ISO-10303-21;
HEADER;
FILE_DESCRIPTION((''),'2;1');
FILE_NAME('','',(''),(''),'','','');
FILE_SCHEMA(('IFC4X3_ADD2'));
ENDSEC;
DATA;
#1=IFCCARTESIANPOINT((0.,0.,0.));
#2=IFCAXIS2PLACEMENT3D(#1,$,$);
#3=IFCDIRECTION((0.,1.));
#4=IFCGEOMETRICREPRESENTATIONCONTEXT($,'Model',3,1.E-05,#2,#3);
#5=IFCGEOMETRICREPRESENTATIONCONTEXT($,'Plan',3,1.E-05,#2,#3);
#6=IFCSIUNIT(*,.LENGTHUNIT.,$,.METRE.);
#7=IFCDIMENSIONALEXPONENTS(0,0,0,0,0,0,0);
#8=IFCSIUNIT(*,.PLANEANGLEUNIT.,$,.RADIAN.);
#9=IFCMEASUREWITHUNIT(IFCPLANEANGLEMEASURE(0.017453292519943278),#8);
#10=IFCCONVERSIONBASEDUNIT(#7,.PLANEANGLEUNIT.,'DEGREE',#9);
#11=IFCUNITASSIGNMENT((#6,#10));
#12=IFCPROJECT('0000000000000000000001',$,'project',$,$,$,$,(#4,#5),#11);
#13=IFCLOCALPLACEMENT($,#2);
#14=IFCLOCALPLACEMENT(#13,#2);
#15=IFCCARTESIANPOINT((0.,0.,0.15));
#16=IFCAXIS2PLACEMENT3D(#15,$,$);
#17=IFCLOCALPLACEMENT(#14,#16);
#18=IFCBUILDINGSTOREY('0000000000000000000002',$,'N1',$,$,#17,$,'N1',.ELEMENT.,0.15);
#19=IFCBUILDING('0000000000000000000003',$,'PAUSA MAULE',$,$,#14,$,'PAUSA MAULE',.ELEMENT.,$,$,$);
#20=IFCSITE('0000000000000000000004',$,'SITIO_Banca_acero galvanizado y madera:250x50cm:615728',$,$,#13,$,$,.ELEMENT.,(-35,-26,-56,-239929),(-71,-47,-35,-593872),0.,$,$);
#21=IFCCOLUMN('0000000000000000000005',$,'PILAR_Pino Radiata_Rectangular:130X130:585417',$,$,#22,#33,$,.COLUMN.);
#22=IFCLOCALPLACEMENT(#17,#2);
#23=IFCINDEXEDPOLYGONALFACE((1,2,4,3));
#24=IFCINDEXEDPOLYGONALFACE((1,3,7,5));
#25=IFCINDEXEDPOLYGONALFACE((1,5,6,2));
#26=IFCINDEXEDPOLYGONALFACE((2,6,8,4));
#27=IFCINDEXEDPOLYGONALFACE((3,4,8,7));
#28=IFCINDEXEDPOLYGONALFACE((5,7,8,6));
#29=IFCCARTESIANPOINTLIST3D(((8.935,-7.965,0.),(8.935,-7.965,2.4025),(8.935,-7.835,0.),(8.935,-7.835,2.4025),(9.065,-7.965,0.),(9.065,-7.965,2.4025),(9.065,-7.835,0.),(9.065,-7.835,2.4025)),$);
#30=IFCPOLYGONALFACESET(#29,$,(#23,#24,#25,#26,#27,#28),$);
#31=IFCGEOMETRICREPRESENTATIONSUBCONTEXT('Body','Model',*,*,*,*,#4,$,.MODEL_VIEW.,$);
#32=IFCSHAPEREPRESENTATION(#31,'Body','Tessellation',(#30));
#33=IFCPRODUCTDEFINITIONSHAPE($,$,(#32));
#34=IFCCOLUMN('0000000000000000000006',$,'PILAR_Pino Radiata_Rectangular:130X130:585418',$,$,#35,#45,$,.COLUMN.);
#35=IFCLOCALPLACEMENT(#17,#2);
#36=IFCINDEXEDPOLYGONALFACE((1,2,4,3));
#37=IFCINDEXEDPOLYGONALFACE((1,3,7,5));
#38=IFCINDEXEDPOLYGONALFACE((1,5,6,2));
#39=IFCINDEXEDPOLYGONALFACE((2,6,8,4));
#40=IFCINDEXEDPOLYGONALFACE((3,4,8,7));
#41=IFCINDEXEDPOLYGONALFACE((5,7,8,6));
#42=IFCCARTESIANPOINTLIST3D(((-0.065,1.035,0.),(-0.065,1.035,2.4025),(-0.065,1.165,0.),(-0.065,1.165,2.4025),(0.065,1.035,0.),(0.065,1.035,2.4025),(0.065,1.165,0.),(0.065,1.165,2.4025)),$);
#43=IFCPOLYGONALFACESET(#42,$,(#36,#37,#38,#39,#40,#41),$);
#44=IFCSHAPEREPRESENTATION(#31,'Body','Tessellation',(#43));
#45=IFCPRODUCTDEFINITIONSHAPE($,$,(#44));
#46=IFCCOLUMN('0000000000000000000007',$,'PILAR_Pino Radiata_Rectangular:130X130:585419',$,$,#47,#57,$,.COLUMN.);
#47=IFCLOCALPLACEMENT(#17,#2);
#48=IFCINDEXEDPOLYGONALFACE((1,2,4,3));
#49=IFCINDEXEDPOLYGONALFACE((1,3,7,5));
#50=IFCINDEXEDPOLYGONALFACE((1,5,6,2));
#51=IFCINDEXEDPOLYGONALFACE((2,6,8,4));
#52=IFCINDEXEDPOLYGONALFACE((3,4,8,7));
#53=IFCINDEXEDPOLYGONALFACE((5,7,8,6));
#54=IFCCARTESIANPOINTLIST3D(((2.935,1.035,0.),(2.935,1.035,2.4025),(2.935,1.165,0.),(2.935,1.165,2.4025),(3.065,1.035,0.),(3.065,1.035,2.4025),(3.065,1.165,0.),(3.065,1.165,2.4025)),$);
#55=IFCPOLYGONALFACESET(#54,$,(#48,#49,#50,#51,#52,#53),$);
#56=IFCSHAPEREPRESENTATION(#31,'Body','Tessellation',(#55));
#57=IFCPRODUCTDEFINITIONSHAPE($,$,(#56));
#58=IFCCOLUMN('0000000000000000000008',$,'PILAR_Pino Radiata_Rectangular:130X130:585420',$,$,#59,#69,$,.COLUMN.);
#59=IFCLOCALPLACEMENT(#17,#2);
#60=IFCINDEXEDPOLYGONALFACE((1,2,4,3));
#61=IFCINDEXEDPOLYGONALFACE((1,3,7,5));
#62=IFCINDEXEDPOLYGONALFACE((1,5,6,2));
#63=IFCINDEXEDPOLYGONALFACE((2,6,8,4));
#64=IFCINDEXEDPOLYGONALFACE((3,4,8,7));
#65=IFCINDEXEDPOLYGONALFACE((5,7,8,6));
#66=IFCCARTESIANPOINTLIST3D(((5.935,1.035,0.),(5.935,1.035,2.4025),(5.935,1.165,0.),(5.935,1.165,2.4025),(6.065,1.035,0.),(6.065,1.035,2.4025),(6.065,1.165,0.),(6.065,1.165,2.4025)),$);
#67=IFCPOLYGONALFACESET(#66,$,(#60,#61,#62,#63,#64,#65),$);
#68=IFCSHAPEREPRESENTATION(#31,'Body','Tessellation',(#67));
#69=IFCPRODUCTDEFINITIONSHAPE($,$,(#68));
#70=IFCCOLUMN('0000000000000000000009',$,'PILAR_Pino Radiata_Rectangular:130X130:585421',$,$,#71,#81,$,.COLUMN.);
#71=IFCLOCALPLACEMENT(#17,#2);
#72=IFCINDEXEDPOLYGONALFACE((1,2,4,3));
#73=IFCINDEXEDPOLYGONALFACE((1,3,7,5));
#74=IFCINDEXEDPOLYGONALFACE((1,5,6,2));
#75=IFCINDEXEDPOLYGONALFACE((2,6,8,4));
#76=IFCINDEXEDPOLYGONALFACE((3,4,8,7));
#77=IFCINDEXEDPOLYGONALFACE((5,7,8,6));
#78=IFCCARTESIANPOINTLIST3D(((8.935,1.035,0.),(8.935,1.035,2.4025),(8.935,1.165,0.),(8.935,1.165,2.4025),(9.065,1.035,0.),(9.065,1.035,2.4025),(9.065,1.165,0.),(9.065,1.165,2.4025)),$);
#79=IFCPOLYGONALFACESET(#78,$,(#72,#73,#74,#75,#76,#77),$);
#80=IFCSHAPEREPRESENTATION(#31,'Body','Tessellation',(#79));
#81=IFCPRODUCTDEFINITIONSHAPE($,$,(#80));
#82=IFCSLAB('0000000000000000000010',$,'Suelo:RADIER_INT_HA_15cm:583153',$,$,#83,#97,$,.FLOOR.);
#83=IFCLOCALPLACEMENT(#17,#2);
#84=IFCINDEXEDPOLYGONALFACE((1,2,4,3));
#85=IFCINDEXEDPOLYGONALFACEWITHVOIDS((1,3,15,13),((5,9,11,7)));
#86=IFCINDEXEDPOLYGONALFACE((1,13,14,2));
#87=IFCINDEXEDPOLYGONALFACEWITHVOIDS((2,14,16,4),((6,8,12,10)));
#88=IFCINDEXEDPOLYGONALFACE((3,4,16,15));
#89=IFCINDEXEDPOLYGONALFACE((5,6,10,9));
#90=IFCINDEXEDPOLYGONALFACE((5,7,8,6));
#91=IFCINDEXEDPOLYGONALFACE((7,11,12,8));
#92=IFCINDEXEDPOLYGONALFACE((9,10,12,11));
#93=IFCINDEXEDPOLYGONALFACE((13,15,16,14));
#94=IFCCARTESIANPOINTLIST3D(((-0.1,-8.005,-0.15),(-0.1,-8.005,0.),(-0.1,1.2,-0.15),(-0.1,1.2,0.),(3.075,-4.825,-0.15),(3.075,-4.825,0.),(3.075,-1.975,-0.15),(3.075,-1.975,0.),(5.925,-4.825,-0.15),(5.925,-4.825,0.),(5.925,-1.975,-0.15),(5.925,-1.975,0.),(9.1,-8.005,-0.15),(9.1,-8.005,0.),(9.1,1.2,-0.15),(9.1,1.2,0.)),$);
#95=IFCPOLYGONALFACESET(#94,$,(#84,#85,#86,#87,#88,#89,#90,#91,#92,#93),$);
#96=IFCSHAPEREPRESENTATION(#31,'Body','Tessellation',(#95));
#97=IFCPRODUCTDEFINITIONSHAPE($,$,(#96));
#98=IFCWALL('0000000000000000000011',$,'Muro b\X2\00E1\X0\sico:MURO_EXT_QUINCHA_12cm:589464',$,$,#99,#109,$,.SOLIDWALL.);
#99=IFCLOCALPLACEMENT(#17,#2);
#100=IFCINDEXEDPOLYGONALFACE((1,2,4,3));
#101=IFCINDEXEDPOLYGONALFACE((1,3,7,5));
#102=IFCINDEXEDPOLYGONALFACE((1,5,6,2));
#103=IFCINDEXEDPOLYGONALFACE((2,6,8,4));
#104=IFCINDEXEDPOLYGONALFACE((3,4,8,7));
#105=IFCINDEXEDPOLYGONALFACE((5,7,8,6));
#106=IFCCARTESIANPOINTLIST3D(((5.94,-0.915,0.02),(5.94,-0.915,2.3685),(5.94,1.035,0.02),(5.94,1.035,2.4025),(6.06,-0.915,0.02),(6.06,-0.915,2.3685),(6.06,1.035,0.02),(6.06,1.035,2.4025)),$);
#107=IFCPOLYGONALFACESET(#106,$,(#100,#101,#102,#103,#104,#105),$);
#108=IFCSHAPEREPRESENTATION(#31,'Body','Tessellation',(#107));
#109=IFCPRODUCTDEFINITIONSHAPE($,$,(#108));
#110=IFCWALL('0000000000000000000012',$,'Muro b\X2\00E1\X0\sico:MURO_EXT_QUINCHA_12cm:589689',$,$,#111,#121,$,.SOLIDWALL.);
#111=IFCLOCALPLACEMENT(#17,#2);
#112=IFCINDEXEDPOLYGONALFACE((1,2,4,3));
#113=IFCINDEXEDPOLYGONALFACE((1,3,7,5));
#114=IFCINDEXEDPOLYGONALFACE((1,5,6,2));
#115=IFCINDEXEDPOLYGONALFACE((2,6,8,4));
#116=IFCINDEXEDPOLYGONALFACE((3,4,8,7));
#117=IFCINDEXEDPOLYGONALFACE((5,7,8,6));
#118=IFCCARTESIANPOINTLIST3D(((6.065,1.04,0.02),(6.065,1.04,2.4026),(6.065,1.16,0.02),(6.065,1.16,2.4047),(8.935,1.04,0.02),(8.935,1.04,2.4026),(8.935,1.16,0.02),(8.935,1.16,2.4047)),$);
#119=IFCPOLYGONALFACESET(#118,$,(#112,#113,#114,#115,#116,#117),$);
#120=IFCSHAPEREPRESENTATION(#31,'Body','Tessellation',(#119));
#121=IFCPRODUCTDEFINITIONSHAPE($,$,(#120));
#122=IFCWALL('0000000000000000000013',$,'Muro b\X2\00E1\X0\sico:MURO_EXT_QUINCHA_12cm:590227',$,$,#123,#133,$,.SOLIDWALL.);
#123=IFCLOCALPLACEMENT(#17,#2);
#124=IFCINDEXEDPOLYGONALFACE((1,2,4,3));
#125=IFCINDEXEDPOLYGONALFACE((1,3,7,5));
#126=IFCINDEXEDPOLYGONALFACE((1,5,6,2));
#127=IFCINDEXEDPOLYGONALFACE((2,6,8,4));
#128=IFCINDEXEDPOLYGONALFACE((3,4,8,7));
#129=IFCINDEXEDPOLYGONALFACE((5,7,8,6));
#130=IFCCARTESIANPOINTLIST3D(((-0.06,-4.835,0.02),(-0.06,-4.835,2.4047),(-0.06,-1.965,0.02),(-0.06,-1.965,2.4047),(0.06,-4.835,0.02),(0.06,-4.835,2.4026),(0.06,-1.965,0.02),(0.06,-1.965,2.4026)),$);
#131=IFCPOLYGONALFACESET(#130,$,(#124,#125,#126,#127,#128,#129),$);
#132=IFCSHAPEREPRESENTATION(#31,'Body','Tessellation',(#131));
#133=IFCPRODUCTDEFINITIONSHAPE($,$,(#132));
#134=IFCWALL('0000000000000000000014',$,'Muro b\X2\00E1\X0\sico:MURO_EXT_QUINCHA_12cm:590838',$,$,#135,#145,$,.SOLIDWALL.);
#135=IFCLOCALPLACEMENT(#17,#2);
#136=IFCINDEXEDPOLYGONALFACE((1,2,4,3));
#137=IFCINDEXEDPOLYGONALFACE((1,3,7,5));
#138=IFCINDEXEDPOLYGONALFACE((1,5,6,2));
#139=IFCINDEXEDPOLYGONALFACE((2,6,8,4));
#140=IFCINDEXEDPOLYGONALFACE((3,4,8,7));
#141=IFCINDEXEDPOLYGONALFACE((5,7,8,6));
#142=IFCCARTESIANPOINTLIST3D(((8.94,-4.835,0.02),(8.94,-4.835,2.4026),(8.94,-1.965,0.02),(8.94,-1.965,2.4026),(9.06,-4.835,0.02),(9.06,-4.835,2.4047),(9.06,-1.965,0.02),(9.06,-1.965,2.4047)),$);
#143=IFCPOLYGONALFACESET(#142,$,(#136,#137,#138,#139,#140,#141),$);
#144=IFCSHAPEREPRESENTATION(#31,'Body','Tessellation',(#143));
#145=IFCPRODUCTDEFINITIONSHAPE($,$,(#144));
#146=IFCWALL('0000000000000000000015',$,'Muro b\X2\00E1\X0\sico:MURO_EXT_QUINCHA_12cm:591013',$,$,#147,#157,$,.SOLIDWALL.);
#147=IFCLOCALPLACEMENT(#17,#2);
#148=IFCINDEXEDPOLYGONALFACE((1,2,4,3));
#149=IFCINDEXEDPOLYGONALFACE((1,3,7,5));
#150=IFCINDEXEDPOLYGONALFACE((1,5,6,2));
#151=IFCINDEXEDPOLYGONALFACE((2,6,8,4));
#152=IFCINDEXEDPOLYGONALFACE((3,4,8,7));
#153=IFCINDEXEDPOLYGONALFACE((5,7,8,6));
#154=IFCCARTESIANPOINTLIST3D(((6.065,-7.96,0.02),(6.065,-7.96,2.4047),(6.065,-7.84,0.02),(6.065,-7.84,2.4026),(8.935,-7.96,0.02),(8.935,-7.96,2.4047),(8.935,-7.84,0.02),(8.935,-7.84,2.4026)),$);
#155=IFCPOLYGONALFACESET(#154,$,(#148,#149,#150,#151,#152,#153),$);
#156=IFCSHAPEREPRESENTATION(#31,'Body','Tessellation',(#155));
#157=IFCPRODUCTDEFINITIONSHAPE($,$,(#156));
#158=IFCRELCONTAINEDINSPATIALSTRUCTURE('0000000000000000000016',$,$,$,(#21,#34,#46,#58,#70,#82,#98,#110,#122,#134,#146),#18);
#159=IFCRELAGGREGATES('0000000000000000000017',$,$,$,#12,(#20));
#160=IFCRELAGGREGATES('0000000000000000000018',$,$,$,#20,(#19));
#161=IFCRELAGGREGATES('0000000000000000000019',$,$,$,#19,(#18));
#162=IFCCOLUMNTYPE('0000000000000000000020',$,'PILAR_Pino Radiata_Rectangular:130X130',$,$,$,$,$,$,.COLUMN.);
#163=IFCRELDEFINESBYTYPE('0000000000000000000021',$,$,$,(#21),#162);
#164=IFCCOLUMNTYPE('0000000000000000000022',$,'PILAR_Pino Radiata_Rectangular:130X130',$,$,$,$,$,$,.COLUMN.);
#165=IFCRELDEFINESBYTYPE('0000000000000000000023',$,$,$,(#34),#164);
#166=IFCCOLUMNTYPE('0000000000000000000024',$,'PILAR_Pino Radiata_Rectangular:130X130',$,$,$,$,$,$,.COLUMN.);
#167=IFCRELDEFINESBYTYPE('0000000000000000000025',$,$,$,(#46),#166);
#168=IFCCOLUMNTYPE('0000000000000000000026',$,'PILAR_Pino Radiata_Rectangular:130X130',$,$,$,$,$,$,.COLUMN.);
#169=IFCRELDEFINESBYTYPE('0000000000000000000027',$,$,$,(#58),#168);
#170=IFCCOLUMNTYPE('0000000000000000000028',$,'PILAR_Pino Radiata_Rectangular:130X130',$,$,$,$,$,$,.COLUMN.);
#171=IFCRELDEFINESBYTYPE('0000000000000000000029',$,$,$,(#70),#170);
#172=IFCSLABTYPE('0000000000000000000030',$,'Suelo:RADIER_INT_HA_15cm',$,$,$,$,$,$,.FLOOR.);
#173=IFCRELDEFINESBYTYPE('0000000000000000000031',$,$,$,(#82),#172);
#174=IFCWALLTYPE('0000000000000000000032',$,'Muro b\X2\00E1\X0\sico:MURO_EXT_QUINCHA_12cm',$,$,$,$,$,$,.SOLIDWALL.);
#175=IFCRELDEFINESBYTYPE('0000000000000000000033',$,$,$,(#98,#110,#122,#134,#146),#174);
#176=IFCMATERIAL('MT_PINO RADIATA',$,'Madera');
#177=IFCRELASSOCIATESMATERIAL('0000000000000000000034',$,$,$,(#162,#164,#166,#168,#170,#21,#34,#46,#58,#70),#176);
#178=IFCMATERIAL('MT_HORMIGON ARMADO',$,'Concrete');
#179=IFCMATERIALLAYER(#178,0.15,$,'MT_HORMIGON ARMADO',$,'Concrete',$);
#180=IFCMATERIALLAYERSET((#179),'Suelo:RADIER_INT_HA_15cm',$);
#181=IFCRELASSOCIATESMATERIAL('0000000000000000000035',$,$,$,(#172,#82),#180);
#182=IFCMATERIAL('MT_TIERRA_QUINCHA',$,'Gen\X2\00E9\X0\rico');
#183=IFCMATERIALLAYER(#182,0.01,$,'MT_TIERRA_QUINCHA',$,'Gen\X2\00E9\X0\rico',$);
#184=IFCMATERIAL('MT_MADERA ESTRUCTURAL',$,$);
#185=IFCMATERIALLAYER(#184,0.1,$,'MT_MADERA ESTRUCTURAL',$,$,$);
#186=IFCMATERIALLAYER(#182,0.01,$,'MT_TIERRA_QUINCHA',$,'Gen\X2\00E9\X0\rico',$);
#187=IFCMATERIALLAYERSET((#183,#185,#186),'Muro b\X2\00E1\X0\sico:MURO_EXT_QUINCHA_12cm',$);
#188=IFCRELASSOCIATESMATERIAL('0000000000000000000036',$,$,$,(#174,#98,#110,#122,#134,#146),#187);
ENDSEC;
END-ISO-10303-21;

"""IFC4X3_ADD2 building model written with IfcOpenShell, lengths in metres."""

from ifc_helpers import new_model, entity, si_unit, converted_unit, direction, frame, frame_2d, origin, origin_2d_with_axis, place, context, subcontext, project, spatial, polyline, rectangle, extrude, boolean, clip, bounded_halfspace, source, transform, mapped, material, layer, layer_set, layer_usage, material_profile, profile_set, profile_usage, type_object, type_shapes, element, save


model = new_model("IFC4X3_ADD2")

# Units and contexts
model_context = context("Model", 3, precision=1e-05, world=origin(), true_north=direction((0.0, 1.0)))
plan_context = context("Plan", 3, precision=1e-05, world=origin(), true_north=direction((0.0, 1.0)))
body_context = subcontext(model_context, "Body", "Model", "MODEL_VIEW")
ifc_project = project(units=[si_unit("LENGTHUNIT", "METRE"), converted_unit("PLANEANGLEUNIT", "DEGREE", entity("IfcPlaneAngleMeasure", 0.017453292519943278), si_unit("PLANEANGLEUNIT", "RADIAN"), dimensions=[0, 0, 0, 0, 0, 0, 0])], contexts=[model_context, plan_context])

# Site, building, storey
site_placement = place(None, origin())
site = spatial("IfcSite", under=ifc_project, at=site_placement, Name="SITIO_Banca_acero galvanizado y madera:250x50cm:615728", CompositionType="ELEMENT", RefLatitude=(-35, -26, -56, -239929), RefLongitude=(-71, -47, -35, -593872), RefElevation=0.0)
building_placement = place(site_placement, origin())
building = spatial("IfcBuilding", under=site, at=building_placement, Name="PAUSA MAULE", LongName="PAUSA MAULE", CompositionType="ELEMENT")
storey_placement = place(building_placement, frame((0.0, 0.0, 0.15)))
storey = spatial("IfcBuildingStorey", under=building, at=storey_placement, Name="N1", LongName="N1", CompositionType="ELEMENT", Elevation=0.15)

# Columns
ifc_material_1 = material(Name="MT_PINO RADIATA", Category="Madera")
ifc_material_profile = material_profile(ifc_material_1, rectangle(XDim=0.13, YDim=0.13, at=frame_2d((0.0, 0.0), x_axis=(1.0, 0.0))), Name="130X130")
ifc_profile_set = profile_set([ifc_material_profile], Name="130X130")
ifc_profile_usage = profile_usage(ifc_profile_set)
column_type_1 = type_object("IfcColumnType", Name="PILAR_Pino Radiata_Rectangular:130X130", PredefinedType="COLUMN", material=ifc_profile_set)
shared_shape_1 = source(origin(), body_context, "Body", "SweptSolid", [
    extrude(rectangle(XDim=0.13, YDim=0.13, at=frame_2d((0.0, 0.0), x_axis=(1.0, 0.0))), frame((9.0, -7.9, 0.15)), (0.0, 0.0, 1.0), 2.4025),
])
type_shapes(column_type_1, [shared_shape_1])
column_1_placement = place(storey_placement, frame((0.0, 0.0, -0.15)))
element("IfcColumn", 1, at=column_1_placement, inside=storey, type_object=column_type_1, material=ifc_profile_usage, Name="PILAR_Pino Radiata_Rectangular:130X130:585417", PredefinedType="COLUMN", context=body_context, shape_type="MappedRepresentation", body=[
    mapped(shared_shape_1, transform((0.0, 0.0, 0.0), scale=1.0)),
])
column_type_2 = type_object("IfcColumnType", Name="PILAR_Pino Radiata_Rectangular:130X130", PredefinedType="COLUMN", material=ifc_profile_set)
shared_shape_2 = source(origin(), body_context, "Body", "SweptSolid", [
    extrude(rectangle(XDim=0.13, YDim=0.13, at=origin_2d_with_axis()), frame((0.0, 1.1, 0.15)), (0.0, 0.0, 1.0), 2.4025),
])
type_shapes(column_type_2, [shared_shape_2])
column_2_placement = place(storey_placement, frame((0.0, 0.0, -0.15)))
element("IfcColumn", 2, at=column_2_placement, inside=storey, type_object=column_type_2, material=ifc_profile_usage, Name="PILAR_Pino Radiata_Rectangular:130X130:585418", PredefinedType="COLUMN", context=body_context, shape_type="MappedRepresentation", body=[
    mapped(shared_shape_2, transform((0.0, 0.0, 0.0), scale=1.0)),
])
column_type_3 = type_object("IfcColumnType", Name="PILAR_Pino Radiata_Rectangular:130X130", PredefinedType="COLUMN", material=ifc_profile_set)
shared_shape_3 = source(origin(), body_context, "Body", "SweptSolid", [
    extrude(rectangle(XDim=0.13, YDim=0.13, at=origin_2d_with_axis()), frame((3.0, 1.1, 0.15)), (0.0, 0.0, 1.0), 2.4025),
])
type_shapes(column_type_3, [shared_shape_3])
column_3_placement = place(storey_placement, frame((0.0, 0.0, -0.15)))
element("IfcColumn", 3, at=column_3_placement, inside=storey, type_object=column_type_3, material=ifc_profile_usage, Name="PILAR_Pino Radiata_Rectangular:130X130:585419", PredefinedType="COLUMN", context=body_context, shape_type="MappedRepresentation", body=[
    mapped(shared_shape_3, transform((0.0, 0.0, 0.0), scale=1.0)),
])
column_type_4 = type_object("IfcColumnType", Name="PILAR_Pino Radiata_Rectangular:130X130", PredefinedType="COLUMN", material=ifc_profile_set)
shared_shape_4 = source(origin(), body_context, "Body", "SweptSolid", [
    extrude(rectangle(XDim=0.13, YDim=0.13, at=frame_2d((0.0, 0.0), x_axis=(1.0, 0.0))), frame((6.0, 1.1, 0.15)), (0.0, 0.0, 1.0), 2.4025),
])
type_shapes(column_type_4, [shared_shape_4])
column_4_placement = place(storey_placement, frame((0.0, 0.0, -0.15)))
element("IfcColumn", 4, at=column_4_placement, inside=storey, type_object=column_type_4, material=ifc_profile_usage, Name="PILAR_Pino Radiata_Rectangular:130X130:585420", PredefinedType="COLUMN", context=body_context, shape_type="MappedRepresentation", body=[
    mapped(shared_shape_4, transform((0.0, 0.0, 0.0), scale=1.0)),
])
column_type_5 = type_object("IfcColumnType", Name="PILAR_Pino Radiata_Rectangular:130X130", PredefinedType="COLUMN", material=ifc_profile_set)
shared_shape_5 = source(origin(), body_context, "Body", "SweptSolid", [
    extrude(rectangle(XDim=0.13, YDim=0.13, at=frame_2d((0.0, 0.0), x_axis=(1.0, 0.0))), frame((9.0, 1.1, 0.15)), (0.0, 0.0, 1.0), 2.4025),
])
type_shapes(column_type_5, [shared_shape_5])
column_5_placement = place(storey_placement, frame((0.0, 0.0, -0.15)))
element("IfcColumn", 5, at=column_5_placement, inside=storey, type_object=column_type_5, material=ifc_profile_usage, Name="PILAR_Pino Radiata_Rectangular:130X130:585421", PredefinedType="COLUMN", context=body_context, shape_type="MappedRepresentation", body=[
    mapped(shared_shape_5, transform((0.0, 0.0, 0.0), scale=1.0)),
])

# Slab, opening
ifc_material_2 = material(Name="MT_HORMIGON ARMADO", Category="Concrete")
ifc_layer_1 = layer(ifc_material_2, 0.15, Name="MT_HORMIGON ARMADO", Category="Concrete")
ifc_layer_set_1 = layer_set([ifc_layer_1], Name="Suelo:RADIER_INT_HA_15cm")
ifc_layer_usage = layer_usage(ifc_layer_set_1, "AXIS3", "POSITIVE", 0.0)
slab_type = type_object("IfcSlabType", Name="Suelo:RADIER_INT_HA_15cm", PredefinedType="FLOOR", material=ifc_layer_set_1)
slab_placement = place(storey_placement, origin())
slab = element("IfcSlab", 6, at=slab_placement, inside=storey, type_object=slab_type, material=ifc_layer_usage, Name="Suelo:RADIER_INT_HA_15cm:583153", PredefinedType="FLOOR", context=body_context, shape_type="CSG", body=[
    boolean("DIFFERENCE", extrude(rectangle(XDim=9.205, YDim=9.2, at=frame_2d((0.0, 0.0), x_axis=(1.0, 0.0))), frame((4.5, -3.4025, 0.0), z_axis=(0.0, 0.0, -1.0), x_axis=(0.0, 1.0, 0.0)), (0.0, 0.0, 1.0), 0.15), extrude(rectangle(XDim=2.85, YDim=2.85, at=origin_2d_with_axis()), frame((4.5, -3.4, -0.15), z_axis=(0.0, 0.0, 1.0), x_axis=(0.0, 1.0, 0.0)), (0.0, 0.0, 1.0), 0.15)),
])
opening_1_placement = place(slab_placement, origin())
element("IfcOpeningElement", 7, at=opening_1_placement, cuts=slab, PredefinedType="OPENING", context=body_context, shape_type="SweptSolid", body=[
    extrude(rectangle(XDim=2.85, YDim=2.85, at=frame_2d((4.5, -3.4), x_axis=(0.0, -1.0))), origin(), (0.0, 0.0, -1.0), 0.15),
])

# Walls
ifc_material_3 = material(Name="MT_TIERRA_QUINCHA", Category="Genérico")
ifc_layer_2 = layer(ifc_material_3, 0.01, Name="MT_TIERRA_QUINCHA", Category="Genérico")
ifc_material_4 = material(Name="MT_MADERA ESTRUCTURAL")
ifc_layer_3 = layer(ifc_material_4, 0.1, Name="MT_MADERA ESTRUCTURAL")
ifc_layer_4 = layer(ifc_material_3, 0.01, Name="MT_TIERRA_QUINCHA", Category="Genérico")
ifc_layer_set_2 = layer_set([ifc_layer_2, ifc_layer_3, ifc_layer_4], Name="Muro básico:MURO_EXT_QUINCHA_12cm")
wall_type = type_object("IfcWallType", Name="Muro básico:MURO_EXT_QUINCHA_12cm", PredefinedType="SOLIDWALL", material=ifc_layer_set_2)
wall_1_placement = place(storey_placement, frame((6.0, -0.915, 0.02), z_axis=(0.0, 0.0, 1.0), x_axis=(0.0, 1.0, 0.0)))
element("IfcWall", 8, at=wall_1_placement, inside=storey, type_object=wall_type, material=ifc_layer_set_2, Name="Muro básico:MURO_EXT_QUINCHA_12cm:589464", PredefinedType="SOLIDWALL", context=body_context, shape_type="Clipping", body=[
    clip(extrude(rectangle(XDim=1.95, YDim=0.12, at=frame_2d((0.975, 0.0), x_axis=(-1.0, 0.0))), origin(), (0.0, 0.0, 1.0), 2.3825), bounded_halfspace(frame((0.0, -0.06, 2.3485), z_axis=(-0.017452, 0.0, 0.999848), x_axis=(0.0, -1.0, 0.0)), False, frame((0.0, -0.06, 2.3485)), polyline([(0.0, 0.0), (1.95, 0.0), (1.95, 0.12), (0.0, 0.12), (0.0, 0.0)]))),
])
wall_2_placement = place(storey_placement, frame((6.065, 1.1, 0.02)))
element("IfcWall", 9, at=wall_2_placement, inside=storey, type_object=wall_type, material=ifc_layer_set_2, Name="Muro básico:MURO_EXT_QUINCHA_12cm:589689", PredefinedType="SOLIDWALL", context=body_context, shape_type="Clipping", body=[
    clip(extrude(rectangle(XDim=2.87, YDim=0.12, at=frame_2d((1.435, 0.0), x_axis=(-1.0, 0.0))), origin(), (0.0, 0.0, 1.0), 2.3847), bounded_halfspace(frame((0.0, -0.06, 2.3826), z_axis=(0.0, -0.017452, 0.999848), x_axis=(1.0, 0.0, 0.0)), False, frame((0.0, -0.06, 2.3826)), polyline([(0.0, 0.0), (2.87, 0.0), (2.87, 0.12), (0.0, 0.12), (0.0, 0.0)]))),
])
wall_3_placement = place(storey_placement, frame((0.0, -1.965, 0.02), z_axis=(0.0, 0.0, 1.0), x_axis=(0.0, -1.0, 0.0)))
element("IfcWall", 10, at=wall_3_placement, inside=storey, type_object=wall_type, material=ifc_layer_set_2, Name="Muro básico:MURO_EXT_QUINCHA_12cm:590227", PredefinedType="SOLIDWALL", context=body_context, shape_type="Clipping", body=[
    clip(extrude(rectangle(XDim=2.87, YDim=0.12, at=frame_2d((1.435, 0.0), x_axis=(-1.0, 0.0))), origin(), (0.0, 0.0, 1.0), 2.3847), bounded_halfspace(frame((0.0, -0.06, 2.3847), z_axis=(0.0, 0.017452, 0.999848), x_axis=(-1.0, 0.0, 0.0)), False, frame((0.0, -0.06, 2.3847)), polyline([(0.0, 0.0), (2.87, 0.0), (2.87, 0.12), (0.0, 0.12), (0.0, 0.0)]))),
])
wall_4_placement = place(storey_placement, frame((9.0, -1.965, 0.02), z_axis=(0.0, 0.0, 1.0), x_axis=(0.0, -1.0, 0.0)))
element("IfcWall", 11, at=wall_4_placement, inside=storey, type_object=wall_type, material=ifc_layer_set_2, Name="Muro básico:MURO_EXT_QUINCHA_12cm:590838", PredefinedType="SOLIDWALL", context=body_context, shape_type="Clipping", body=[
    clip(extrude(rectangle(XDim=2.87, YDim=0.12, at=frame_2d((1.435, 0.0), x_axis=(-1.0, 0.0))), origin(), (0.0, 0.0, 1.0), 2.3847), bounded_halfspace(frame((0.0, -0.06, 2.3826), z_axis=(0.0, -0.017452, 0.999848), x_axis=(1.0, 0.0, 0.0)), False, frame((0.0, -0.06, 2.3826)), polyline([(0.0, 0.0), (2.87, 0.0), (2.87, 0.12), (0.0, 0.12), (0.0, 0.0)]))),
])
wall_5_placement = place(storey_placement, frame((8.935, -7.9, 0.02), z_axis=(0.0, 0.0, 1.0), x_axis=(-1.0, 0.0, 0.0)))
element("IfcWall", 12, at=wall_5_placement, inside=storey, type_object=wall_type, material=ifc_layer_set_2, Name="Muro básico:MURO_EXT_QUINCHA_12cm:591013", PredefinedType="SOLIDWALL", context=body_context, shape_type="Clipping", body=[
    clip(extrude(rectangle(XDim=2.87, YDim=0.12, at=frame_2d((1.435, 0.0), x_axis=(-1.0, 0.0))), origin(), (0.0, 0.0, 1.0), 2.3847), bounded_halfspace(frame((0.0, -0.06, 2.3826), z_axis=(0.0, -0.017452, 0.999848), x_axis=(1.0, 0.0, 0.0)), False, frame((0.0, -0.06, 2.3826)), polyline([(0.0, 0.0), (2.87, 0.0), (2.87, 0.12), (0.0, 0.12), (0.0, 0.0)]))),
])

save(model, "model.ifc")
